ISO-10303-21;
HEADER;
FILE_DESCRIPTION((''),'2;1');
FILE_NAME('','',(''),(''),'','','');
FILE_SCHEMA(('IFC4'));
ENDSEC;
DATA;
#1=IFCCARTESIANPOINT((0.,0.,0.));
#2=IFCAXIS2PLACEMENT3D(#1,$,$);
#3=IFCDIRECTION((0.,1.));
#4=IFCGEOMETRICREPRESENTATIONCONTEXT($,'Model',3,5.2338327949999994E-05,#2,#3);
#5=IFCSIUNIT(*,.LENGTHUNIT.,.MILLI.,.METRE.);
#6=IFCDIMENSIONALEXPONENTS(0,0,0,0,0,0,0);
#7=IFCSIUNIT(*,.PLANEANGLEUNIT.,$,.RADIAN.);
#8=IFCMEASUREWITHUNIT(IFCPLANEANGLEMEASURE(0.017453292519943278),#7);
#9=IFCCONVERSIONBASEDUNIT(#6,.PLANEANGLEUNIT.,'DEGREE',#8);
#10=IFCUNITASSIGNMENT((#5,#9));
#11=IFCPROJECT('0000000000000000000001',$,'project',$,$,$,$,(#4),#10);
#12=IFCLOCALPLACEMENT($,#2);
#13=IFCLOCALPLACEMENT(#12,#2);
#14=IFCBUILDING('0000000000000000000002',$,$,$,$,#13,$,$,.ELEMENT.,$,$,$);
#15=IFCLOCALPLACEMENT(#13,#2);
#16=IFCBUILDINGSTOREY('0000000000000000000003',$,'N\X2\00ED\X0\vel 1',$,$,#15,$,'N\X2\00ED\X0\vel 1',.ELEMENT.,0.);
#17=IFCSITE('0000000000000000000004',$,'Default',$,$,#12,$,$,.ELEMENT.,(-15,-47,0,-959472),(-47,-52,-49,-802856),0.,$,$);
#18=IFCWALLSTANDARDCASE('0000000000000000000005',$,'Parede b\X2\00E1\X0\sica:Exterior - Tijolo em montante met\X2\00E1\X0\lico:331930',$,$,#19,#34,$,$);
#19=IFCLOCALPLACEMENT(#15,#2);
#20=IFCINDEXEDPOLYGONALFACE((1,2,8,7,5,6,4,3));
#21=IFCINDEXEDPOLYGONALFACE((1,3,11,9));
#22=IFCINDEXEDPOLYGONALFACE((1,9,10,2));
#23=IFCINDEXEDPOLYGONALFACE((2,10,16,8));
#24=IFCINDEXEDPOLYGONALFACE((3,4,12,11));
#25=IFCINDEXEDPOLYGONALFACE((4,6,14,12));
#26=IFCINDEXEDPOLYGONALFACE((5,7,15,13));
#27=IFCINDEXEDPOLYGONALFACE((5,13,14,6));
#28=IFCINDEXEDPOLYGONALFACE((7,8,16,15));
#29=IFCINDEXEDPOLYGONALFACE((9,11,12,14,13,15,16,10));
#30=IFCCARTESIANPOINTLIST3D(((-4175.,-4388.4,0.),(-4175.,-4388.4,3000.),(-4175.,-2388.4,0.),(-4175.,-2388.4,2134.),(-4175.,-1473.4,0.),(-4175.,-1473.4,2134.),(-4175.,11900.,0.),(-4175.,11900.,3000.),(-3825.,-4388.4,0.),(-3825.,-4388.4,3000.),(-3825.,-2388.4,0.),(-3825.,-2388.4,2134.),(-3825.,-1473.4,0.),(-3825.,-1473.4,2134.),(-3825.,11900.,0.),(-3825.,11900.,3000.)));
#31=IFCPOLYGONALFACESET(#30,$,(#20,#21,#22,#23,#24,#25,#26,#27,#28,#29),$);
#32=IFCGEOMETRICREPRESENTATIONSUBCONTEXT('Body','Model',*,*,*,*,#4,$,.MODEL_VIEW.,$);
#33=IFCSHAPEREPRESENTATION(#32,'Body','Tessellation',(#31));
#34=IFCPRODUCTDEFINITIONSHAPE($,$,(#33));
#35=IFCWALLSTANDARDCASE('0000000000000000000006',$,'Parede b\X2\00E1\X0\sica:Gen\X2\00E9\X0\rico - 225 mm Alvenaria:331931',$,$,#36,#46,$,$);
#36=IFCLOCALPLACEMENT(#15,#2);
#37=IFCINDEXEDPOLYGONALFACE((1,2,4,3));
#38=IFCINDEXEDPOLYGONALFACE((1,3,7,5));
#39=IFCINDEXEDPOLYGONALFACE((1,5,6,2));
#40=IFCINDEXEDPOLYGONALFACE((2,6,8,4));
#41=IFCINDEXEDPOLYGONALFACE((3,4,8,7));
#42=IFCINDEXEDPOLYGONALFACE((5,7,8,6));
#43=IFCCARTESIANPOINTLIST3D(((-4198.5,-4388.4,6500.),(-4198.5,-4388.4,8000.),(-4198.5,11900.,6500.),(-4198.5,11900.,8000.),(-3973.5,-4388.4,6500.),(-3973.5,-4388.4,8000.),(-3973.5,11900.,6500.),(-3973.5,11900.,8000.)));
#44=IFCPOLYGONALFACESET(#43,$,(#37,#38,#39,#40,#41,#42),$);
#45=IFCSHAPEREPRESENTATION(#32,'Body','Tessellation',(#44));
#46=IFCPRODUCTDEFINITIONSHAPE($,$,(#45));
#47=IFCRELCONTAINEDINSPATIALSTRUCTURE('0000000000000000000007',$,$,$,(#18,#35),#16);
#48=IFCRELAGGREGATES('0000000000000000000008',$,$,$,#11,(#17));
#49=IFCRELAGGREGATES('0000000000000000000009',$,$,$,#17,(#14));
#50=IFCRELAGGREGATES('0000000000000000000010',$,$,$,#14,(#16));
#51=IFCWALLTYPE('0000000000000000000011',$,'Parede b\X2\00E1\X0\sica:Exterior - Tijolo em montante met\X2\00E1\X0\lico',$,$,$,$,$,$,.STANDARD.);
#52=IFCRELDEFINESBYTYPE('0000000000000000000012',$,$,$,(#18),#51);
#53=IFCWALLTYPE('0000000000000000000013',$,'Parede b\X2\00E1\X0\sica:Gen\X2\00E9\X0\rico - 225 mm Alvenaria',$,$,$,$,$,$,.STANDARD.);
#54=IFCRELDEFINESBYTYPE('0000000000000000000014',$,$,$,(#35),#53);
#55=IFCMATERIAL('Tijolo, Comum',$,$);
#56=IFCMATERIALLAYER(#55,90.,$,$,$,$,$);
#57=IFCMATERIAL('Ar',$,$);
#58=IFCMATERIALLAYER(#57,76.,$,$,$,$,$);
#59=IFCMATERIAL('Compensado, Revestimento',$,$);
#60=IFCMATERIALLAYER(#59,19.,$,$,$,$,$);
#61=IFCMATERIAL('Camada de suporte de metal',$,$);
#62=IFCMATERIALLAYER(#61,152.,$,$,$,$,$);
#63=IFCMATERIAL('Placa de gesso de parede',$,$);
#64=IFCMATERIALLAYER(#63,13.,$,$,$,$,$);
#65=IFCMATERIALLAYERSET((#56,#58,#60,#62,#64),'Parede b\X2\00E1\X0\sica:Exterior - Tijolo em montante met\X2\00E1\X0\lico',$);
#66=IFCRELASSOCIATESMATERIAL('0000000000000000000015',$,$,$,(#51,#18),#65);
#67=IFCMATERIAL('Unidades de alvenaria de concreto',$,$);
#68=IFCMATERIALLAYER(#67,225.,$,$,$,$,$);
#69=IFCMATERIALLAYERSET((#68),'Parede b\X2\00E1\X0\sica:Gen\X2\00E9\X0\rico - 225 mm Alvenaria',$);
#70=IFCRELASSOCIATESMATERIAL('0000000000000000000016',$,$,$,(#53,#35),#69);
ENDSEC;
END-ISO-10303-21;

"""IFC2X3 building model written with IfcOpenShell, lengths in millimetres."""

from ifc_helpers import new_model, entity, si_unit, converted_unit, direction, frame, frame_2d, origin, place, context, subcontext, project, spatial, rectangle, extrude, material, layer, layer_set, layer_usage, type_object, element, save


model = new_model("IFC2X3")

# Units and contexts
model_context = context("Model", 3, precision=5.2338327949999994e-05, world=origin(), true_north=direction((0.0, 1.0)))
body_context = subcontext(model_context, "Body", "Model", "MODEL_VIEW")
ifc_project = project(units=[si_unit("LENGTHUNIT", "METRE", prefix="MILLI"), converted_unit("PLANEANGLEUNIT", "DEGREE", entity("IfcPlaneAngleMeasure", 0.017453292519943278), si_unit("PLANEANGLEUNIT", "RADIAN"), dimensions=[0, 0, 0, 0, 0, 0, 0])], contexts=[model_context])

# Site, building, storey
site_placement = place(None, origin())
site = spatial("IfcSite", under=ifc_project, at=site_placement, Name="Default", CompositionType="ELEMENT", RefLatitude=(-15, -47, 0, -959472), RefLongitude=(-47, -52, -49, -802856), RefElevation=0.0)
building_placement = place(site_placement, origin())
building = spatial("IfcBuilding", under=site, at=building_placement, CompositionType="ELEMENT")
storey_placement = place(building_placement, origin())
storey = spatial("IfcBuildingStorey", under=building, at=storey_placement, Name="Nível 1", LongName="Nível 1", CompositionType="ELEMENT", Elevation=0.0)

# Wall, opening
ifc_material_1 = material(Name="Tijolo, Comum")
ifc_layer_1 = layer(ifc_material_1, 90.0)
ifc_material_2 = material(Name="Ar")
ifc_layer_2 = layer(ifc_material_2, 76.0)
ifc_material_3 = material(Name="Compensado, Revestimento")
ifc_layer_3 = layer(ifc_material_3, 19.0)
ifc_material_4 = material(Name="Camada de suporte de metal")
ifc_layer_4 = layer(ifc_material_4, 152.0)
ifc_material_5 = material(Name="Placa de gesso de parede")
ifc_layer_5 = layer(ifc_material_5, 13.0)
ifc_layer_set_1 = layer_set([ifc_layer_1, ifc_layer_2, ifc_layer_3, ifc_layer_4, ifc_layer_5], Name="Parede básica:Exterior - Tijolo em montante metálico")
ifc_layer_usage_1 = layer_usage(ifc_layer_set_1, "AXIS2", "NEGATIVE", 175.0)
wall_type_1 = type_object("IfcWallType", Name="Parede básica:Exterior - Tijolo em montante metálico", PredefinedType="STANDARD", material=ifc_layer_set_1)
wall_1_placement = place(storey_placement, frame((-4000.0, 11900.0, 0.0), z_axis=(0.0, 0.0, 1.0), x_axis=(0.0, -1.0, 0.0)))
wall_1 = element("IfcWallStandardCase", 1, at=wall_1_placement, inside=storey, type_object=wall_type_1, material=ifc_layer_usage_1, Name="Parede básica:Exterior - Tijolo em montante metálico:331930", context=body_context, shape_type="SweptSolid", body=[
    extrude(rectangle(XDim=16288.4, YDim=350.0, at=frame_2d((8144.2, 0.0), x_axis=(-1.0, 0.0))), origin(), (0.0, 0.0, 1.0), 3000.0),
])
opening_1_placement = place(wall_1_placement, origin())
element("IfcOpeningElement", 2, at=opening_1_placement, cuts=wall_1, ObjectType="Opening", context=body_context, shape_type="SweptSolid", body=[
    extrude(rectangle(XDim=2134.0, YDim=915.0, at=frame_2d((0.0, 0.0), x_axis=(0.0, 1.0))), frame((13830.9, -1460.0, 1067.0), z_axis=(0.0, 1.0, 0.0), x_axis=(-1.0, 0.0, 0.0)), (0.0, 0.0, 1.0), 3048.0),
])

# Wall
ifc_material_6 = material(Name="Unidades de alvenaria de concreto")
ifc_layer_6 = layer(ifc_material_6, 225.0)
ifc_layer_set_2 = layer_set([ifc_layer_6], Name="Parede básica:Genérico - 225 mm Alvenaria")
ifc_layer_usage_2 = layer_usage(ifc_layer_set_2, "AXIS2", "NEGATIVE", 112.5)
wall_type_2 = type_object("IfcWallType", Name="Parede básica:Genérico - 225 mm Alvenaria", PredefinedType="STANDARD", material=ifc_layer_set_2)
wall_2_placement = place(storey_placement, frame((-4086.0, 11900.0, 6500.0), z_axis=(0.0, 0.0, 1.0), x_axis=(0.0, -1.0, 0.0)))
element("IfcWallStandardCase", 3, at=wall_2_placement, inside=storey, type_object=wall_type_2, material=ifc_layer_usage_2, Name="Parede básica:Genérico - 225 mm Alvenaria:331931", context=body_context, shape_type="SweptSolid", body=[
    extrude(rectangle(XDim=16288.4, YDim=225.0, at=frame_2d((8144.2, 0.0), x_axis=(-1.0, 0.0))), origin(), (0.0, 0.0, 1.0), 1500.0),
])

save(model, "model.ifc")
